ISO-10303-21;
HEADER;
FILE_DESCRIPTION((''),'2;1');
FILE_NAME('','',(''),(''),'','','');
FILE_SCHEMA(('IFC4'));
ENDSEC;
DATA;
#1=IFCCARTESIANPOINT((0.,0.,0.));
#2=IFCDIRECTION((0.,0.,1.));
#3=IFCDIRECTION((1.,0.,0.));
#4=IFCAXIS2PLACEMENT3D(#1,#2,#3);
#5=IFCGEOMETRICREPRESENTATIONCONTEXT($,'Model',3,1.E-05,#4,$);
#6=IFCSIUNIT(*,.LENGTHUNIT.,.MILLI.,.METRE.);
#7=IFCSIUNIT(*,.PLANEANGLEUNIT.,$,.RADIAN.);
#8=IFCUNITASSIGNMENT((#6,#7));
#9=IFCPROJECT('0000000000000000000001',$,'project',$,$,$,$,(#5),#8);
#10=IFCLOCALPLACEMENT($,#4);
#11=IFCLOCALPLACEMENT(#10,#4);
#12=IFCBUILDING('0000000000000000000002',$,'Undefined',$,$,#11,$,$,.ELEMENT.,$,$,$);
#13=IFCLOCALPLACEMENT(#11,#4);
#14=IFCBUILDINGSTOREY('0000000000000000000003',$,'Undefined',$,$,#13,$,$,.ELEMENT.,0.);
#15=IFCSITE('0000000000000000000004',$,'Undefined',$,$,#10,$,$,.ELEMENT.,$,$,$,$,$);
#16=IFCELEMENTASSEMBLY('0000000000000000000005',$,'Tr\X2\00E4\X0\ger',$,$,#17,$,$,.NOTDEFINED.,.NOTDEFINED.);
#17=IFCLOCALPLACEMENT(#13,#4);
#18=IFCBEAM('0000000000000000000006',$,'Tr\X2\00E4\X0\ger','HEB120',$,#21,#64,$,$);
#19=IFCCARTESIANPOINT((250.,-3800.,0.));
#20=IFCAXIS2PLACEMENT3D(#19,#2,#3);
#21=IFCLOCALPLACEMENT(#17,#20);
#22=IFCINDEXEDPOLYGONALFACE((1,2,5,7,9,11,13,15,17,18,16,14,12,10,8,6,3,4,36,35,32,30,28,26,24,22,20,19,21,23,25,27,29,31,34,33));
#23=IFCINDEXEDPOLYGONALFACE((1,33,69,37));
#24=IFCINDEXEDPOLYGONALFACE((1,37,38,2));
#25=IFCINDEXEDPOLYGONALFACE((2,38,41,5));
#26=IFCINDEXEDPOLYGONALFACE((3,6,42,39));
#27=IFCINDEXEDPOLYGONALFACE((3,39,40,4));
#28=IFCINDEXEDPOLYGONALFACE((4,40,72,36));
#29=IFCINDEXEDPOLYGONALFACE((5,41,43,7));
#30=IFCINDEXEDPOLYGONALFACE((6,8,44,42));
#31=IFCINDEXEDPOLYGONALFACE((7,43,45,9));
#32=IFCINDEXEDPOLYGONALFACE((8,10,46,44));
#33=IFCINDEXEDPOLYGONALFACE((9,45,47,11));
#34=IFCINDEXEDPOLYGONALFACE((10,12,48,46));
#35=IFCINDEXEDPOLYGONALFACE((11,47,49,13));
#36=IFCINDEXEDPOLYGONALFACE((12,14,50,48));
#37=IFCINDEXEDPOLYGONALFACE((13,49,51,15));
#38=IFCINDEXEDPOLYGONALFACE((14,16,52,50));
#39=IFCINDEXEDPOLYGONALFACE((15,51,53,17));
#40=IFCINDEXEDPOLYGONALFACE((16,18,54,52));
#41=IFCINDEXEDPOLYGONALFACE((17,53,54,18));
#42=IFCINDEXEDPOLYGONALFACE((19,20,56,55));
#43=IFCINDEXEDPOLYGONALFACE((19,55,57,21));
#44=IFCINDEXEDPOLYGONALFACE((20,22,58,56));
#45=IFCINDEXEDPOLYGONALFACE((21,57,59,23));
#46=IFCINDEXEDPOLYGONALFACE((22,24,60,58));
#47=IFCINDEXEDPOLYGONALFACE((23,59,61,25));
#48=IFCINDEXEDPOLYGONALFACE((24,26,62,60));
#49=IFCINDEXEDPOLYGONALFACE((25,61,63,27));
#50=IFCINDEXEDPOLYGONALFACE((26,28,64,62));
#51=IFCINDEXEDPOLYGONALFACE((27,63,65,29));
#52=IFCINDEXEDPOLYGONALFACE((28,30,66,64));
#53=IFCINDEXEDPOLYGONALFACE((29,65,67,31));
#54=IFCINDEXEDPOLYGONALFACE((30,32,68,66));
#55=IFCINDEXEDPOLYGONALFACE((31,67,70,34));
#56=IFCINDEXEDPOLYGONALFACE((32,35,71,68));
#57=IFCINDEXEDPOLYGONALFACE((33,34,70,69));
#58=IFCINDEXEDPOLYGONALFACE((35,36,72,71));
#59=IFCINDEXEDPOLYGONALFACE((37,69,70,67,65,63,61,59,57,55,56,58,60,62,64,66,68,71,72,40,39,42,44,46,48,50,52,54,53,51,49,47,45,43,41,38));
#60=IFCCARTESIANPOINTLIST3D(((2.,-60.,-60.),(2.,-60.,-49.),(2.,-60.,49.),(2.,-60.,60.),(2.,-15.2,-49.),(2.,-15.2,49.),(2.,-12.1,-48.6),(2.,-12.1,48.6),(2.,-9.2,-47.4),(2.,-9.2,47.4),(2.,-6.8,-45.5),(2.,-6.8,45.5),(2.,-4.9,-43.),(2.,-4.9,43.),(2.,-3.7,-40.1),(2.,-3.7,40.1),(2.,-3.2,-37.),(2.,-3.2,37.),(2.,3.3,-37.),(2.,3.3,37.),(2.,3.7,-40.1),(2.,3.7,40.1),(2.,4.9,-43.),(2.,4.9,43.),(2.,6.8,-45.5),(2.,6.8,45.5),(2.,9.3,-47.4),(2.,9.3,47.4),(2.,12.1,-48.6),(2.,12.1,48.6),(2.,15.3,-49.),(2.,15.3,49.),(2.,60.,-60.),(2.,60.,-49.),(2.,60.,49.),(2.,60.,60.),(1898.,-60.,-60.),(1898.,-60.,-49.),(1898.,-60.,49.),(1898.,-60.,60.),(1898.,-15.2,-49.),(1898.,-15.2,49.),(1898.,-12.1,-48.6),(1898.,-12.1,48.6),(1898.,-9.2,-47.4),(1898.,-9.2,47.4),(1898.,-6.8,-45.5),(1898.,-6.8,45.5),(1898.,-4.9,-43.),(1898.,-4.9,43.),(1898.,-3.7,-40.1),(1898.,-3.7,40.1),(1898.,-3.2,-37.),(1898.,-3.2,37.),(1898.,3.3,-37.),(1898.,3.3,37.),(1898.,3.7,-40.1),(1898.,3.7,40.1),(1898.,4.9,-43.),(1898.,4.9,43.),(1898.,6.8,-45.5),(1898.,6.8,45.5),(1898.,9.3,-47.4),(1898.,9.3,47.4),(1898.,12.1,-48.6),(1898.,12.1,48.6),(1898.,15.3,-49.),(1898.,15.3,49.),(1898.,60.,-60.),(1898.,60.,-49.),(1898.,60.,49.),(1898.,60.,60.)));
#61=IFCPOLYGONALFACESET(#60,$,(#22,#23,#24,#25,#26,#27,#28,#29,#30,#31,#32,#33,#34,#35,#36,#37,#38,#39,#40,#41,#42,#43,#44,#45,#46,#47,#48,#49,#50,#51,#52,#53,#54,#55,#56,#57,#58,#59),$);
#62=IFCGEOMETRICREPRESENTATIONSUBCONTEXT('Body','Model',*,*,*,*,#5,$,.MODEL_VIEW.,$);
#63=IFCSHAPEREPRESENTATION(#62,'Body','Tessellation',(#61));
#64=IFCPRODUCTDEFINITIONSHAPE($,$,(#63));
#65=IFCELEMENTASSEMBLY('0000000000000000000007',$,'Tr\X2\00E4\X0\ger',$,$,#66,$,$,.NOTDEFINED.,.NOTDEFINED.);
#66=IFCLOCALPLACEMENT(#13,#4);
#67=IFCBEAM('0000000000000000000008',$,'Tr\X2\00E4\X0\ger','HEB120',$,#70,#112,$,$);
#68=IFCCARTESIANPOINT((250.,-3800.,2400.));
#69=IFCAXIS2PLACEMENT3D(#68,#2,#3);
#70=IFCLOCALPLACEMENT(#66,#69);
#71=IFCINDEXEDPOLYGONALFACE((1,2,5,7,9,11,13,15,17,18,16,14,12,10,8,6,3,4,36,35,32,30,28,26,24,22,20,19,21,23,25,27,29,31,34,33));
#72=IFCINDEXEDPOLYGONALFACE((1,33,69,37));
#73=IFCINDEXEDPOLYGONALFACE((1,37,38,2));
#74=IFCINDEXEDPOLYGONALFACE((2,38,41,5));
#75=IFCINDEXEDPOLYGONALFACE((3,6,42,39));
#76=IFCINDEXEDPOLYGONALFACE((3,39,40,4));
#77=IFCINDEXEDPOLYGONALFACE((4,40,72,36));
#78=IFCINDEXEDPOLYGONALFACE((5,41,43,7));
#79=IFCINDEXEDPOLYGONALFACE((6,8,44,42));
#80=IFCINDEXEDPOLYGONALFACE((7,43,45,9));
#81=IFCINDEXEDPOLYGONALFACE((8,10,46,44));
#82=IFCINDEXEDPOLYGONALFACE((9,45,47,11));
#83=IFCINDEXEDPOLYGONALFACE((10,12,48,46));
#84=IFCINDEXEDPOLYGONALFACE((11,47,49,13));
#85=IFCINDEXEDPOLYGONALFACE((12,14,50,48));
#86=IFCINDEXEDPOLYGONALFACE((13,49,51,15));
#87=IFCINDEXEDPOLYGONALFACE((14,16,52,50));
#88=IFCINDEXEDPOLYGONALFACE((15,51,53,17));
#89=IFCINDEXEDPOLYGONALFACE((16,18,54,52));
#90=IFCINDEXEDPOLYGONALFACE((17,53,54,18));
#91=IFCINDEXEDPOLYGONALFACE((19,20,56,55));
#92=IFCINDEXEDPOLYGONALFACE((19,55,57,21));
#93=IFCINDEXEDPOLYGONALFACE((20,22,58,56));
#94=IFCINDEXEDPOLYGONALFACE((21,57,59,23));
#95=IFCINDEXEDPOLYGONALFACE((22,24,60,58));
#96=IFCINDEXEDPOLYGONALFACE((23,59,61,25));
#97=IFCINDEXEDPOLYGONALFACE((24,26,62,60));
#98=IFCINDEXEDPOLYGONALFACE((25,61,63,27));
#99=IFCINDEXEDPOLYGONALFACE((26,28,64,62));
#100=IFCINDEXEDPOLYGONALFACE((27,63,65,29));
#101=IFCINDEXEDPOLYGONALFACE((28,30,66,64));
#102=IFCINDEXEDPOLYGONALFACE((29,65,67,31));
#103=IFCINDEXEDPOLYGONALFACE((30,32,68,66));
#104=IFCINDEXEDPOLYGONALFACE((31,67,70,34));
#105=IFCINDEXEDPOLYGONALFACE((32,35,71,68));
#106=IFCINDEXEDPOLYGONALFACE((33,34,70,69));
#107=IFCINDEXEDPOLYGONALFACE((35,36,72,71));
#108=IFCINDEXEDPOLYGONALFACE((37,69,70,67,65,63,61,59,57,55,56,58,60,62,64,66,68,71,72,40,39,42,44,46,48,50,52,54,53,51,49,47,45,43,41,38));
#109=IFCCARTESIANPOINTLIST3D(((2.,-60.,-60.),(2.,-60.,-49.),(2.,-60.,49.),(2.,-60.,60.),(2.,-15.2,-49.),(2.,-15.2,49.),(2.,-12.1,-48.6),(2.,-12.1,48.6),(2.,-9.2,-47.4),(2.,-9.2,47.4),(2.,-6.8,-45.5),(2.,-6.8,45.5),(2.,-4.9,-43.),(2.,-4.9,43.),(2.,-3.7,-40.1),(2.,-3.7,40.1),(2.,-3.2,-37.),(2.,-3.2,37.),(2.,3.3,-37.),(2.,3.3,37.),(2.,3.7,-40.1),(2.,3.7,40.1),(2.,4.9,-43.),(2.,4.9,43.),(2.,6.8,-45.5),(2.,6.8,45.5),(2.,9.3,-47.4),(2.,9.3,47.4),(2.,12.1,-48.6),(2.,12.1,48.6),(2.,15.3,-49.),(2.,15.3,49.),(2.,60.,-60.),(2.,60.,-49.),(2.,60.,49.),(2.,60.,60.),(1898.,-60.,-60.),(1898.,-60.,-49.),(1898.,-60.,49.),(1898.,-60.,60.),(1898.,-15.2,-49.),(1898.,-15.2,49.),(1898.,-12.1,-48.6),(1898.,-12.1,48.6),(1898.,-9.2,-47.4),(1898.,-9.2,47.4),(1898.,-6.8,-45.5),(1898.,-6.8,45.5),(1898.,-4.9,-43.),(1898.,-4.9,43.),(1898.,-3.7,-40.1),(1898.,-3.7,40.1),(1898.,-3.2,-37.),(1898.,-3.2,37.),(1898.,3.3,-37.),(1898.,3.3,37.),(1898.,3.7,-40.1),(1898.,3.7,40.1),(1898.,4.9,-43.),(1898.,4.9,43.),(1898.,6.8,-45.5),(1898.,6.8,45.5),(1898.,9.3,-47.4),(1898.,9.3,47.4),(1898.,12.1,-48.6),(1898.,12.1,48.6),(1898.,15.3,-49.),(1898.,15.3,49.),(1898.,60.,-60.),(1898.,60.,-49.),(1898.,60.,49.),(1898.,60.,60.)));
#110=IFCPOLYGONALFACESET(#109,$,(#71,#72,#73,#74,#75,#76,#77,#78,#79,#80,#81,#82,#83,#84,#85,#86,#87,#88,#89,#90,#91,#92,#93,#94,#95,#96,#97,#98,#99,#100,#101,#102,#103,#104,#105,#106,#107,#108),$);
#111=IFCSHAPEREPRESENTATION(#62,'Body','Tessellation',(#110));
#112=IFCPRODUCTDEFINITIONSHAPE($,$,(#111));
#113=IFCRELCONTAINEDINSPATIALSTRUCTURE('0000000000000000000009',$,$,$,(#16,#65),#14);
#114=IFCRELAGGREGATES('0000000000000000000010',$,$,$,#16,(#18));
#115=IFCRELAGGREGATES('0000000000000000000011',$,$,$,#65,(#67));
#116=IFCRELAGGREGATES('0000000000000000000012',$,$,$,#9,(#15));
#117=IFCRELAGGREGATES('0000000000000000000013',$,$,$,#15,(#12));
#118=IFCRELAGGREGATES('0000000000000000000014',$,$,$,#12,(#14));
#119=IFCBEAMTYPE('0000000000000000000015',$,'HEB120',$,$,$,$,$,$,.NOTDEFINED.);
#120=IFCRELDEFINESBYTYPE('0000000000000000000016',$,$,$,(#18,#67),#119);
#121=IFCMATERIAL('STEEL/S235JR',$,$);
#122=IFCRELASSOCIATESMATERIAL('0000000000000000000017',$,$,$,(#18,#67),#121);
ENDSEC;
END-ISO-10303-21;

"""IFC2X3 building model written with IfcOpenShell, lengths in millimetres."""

from ifc_helpers import new_model, si_unit, frame, origin_with_axes, origin_2d_with_axis, place, context, subcontext, project, spatial, i_section, extrude, clip, halfspace, material, type_object, element, aggregate, save


model = new_model("IFC2X3")

# Units and contexts
model_context = context("Model", 3, precision=1e-05, world=origin_with_axes())
body_context = subcontext(model_context, "Body", "Model", "MODEL_VIEW")
ifc_project = project(units=[si_unit("LENGTHUNIT", "METRE", prefix="MILLI"), si_unit("PLANEANGLEUNIT", "RADIAN")], contexts=[model_context])

# Site, building, storey
site_placement = place(None, origin_with_axes())
site = spatial("IfcSite", under=ifc_project, at=site_placement, Name="Undefined", CompositionType="ELEMENT")
building_placement = place(site_placement, origin_with_axes())
building = spatial("IfcBuilding", under=site, at=building_placement, Name="Undefined", CompositionType="ELEMENT")
storey_placement = place(building_placement, origin_with_axes())
storey = spatial("IfcBuildingStorey", under=building, at=storey_placement, Name="Undefined", CompositionType="ELEMENT", Elevation=0.0)

# Shared definitions
ifc_material_1 = material(Name="STEEL/S235JR")

# Element assembly, beam
beam_type_1 = type_object("IfcBeamType", Name="HEB120", PredefinedType="NOTDEFINED")
assembly_1_placement = place(storey_placement, origin_with_axes())
assembly_1 = element("IfcElementAssembly", 1, at=assembly_1_placement, inside=storey, Name="Träger", AssemblyPlace="NOTDEFINED", PredefinedType="NOTDEFINED")
beam_1_placement = place(assembly_1_placement, frame((250.0, -3800.0, 0.0), z_axis=(0.0, 0.0, 1.0), x_axis=(1.0, 0.0, 0.0)))
beam_1 = element("IfcBeam", 2, at=beam_1_placement, type_object=beam_type_1, material=ifc_material_1, Name="Träger", Description="HEB120", context=body_context, shape_type="Clipping", body=[
    clip(clip(extrude(i_section(OverallWidth=120.0, OverallDepth=120.0, WebThickness=6.5, FlangeThickness=11.0, FilletRadius=12.0, at=origin_2d_with_axis()), frame((1910.0, 0.0, 0.0), z_axis=(-1.0, 0.0, 0.0), x_axis=(0.0, -1.0, 0.0)), (0.0, 0.0, 1.0), 1910.0), halfspace(frame((1898.0, 0.0, -60.0), z_axis=(-1.0, 0.0, 0.0), x_axis=(0.0, 1.0, 0.0)), True)), halfspace(frame((2.0, 0.0, -60.0), z_axis=(1.0, 0.0, 0.0), x_axis=(0.0, -1.0, 0.0)), True)),
])
aggregate(assembly_1, [beam_1])

# Element assembly, beam
assembly_2_placement = place(storey_placement, origin_with_axes())
assembly_2 = element("IfcElementAssembly", 3, at=assembly_2_placement, inside=storey, Name="Träger", AssemblyPlace="NOTDEFINED", PredefinedType="NOTDEFINED")
beam_2_placement = place(assembly_2_placement, frame((250.0, -3800.0, 2400.0), z_axis=(0.0, 0.0, 1.0), x_axis=(1.0, 0.0, 0.0)))
beam_2 = element("IfcBeam", 4, at=beam_2_placement, type_object=beam_type_1, material=ifc_material_1, Name="Träger", Description="HEB120", context=body_context, shape_type="Clipping", body=[
    clip(clip(extrude(i_section(OverallWidth=120.0, OverallDepth=120.0, WebThickness=6.5, FlangeThickness=11.0, FilletRadius=12.0, at=origin_2d_with_axis()), frame((1910.0, 0.0, 0.0), z_axis=(-1.0, 0.0, 0.0), x_axis=(0.0, -1.0, 0.0)), (0.0, 0.0, 1.0), 1910.0), halfspace(frame((1898.0, 0.0, -60.0), z_axis=(-1.0, 0.0, 0.0), x_axis=(0.0, 1.0, 0.0)), True)), halfspace(frame((2.0, 0.0, -60.0), z_axis=(1.0, 0.0, 0.0), x_axis=(0.0, -1.0, 0.0)), True)),
])

aggregate(assembly_2, [beam_2])

save(model, "model.ifc")
